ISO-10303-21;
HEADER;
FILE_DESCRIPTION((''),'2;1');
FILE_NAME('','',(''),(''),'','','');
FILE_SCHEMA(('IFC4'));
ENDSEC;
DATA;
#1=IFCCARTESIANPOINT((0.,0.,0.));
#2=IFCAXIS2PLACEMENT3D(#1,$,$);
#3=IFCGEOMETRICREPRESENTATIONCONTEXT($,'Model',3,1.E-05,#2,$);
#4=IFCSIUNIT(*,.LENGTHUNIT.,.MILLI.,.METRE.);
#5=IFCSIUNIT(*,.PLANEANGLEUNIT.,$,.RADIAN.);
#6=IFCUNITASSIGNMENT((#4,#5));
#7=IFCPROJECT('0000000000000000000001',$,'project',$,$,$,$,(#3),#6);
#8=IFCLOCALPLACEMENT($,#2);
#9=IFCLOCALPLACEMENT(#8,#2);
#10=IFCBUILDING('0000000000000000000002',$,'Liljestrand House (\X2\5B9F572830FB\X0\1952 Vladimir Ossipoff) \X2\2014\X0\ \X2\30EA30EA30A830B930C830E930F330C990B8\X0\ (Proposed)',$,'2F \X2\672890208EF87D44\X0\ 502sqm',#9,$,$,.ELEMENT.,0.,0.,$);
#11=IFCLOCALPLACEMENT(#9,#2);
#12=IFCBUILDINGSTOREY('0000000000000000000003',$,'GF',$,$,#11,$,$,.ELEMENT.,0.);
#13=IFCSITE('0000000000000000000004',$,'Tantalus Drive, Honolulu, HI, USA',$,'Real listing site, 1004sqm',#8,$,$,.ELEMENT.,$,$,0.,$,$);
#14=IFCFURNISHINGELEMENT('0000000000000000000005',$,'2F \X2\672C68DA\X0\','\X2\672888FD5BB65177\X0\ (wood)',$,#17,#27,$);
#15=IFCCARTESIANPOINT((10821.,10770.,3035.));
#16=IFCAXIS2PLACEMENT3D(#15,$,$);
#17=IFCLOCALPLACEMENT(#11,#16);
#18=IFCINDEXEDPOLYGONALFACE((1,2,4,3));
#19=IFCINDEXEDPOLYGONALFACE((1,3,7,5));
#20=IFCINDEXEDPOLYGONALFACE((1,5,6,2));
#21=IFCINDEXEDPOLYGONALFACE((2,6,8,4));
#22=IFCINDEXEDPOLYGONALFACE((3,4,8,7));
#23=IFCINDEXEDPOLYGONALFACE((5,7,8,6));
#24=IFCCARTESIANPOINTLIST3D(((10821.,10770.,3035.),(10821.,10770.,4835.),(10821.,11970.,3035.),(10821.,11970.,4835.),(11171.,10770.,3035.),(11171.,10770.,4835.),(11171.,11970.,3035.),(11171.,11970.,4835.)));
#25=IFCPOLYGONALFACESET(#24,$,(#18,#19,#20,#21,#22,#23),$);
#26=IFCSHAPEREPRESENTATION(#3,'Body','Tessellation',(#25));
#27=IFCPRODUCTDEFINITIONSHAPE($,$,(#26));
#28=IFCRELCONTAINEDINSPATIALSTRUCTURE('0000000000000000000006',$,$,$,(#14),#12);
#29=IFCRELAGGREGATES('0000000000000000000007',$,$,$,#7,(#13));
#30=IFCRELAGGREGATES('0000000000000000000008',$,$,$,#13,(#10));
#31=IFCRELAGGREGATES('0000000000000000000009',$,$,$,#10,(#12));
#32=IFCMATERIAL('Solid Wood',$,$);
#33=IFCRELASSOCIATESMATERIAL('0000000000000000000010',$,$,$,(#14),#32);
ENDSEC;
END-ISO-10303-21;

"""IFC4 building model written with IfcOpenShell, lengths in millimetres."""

from ifc_helpers import new_model, si_unit, frame, frame_2d, origin, place, context, project, spatial, rectangle, extrude, material, element, save


model = new_model("IFC4")

# Units and contexts
model_context = context("Model", 3, precision=1e-05, world=origin())
ifc_project = project(units=[si_unit("LENGTHUNIT", "METRE", prefix="MILLI"), si_unit("PLANEANGLEUNIT", "RADIAN")], contexts=[model_context])

# Site, building, storey
site_placement = place(None, origin())
site = spatial("IfcSite", under=ifc_project, at=site_placement, Name="Tantalus Drive, Honolulu, HI, USA", ObjectType="Real listing site, 1004sqm", CompositionType="ELEMENT", RefElevation=0.0)
building_placement = place(site_placement, origin())
building = spatial("IfcBuilding", under=site, at=building_placement, Name="Liljestrand House (実在・1952 Vladimir Ossipoff) — リリエストランド邸 (Proposed)", ObjectType="2F 木造軸組 502sqm", CompositionType="ELEMENT", ElevationOfRefHeight=0.0, ElevationOfTerrain=0.0)
storey_placement = place(building_placement, origin())
storey = spatial("IfcBuildingStorey", under=building, at=storey_placement, Name="GF", CompositionType="ELEMENT", Elevation=0.0)

# Shared definitions
ifc_material_1 = material(Name="Solid Wood")

# Furnishing element
furnishing_1_placement = place(storey_placement, frame((10821.0, 10770.0, 3035.0)))
element("IfcFurnishingElement", 1, at=furnishing_1_placement, inside=storey, material=ifc_material_1, Name="2F 本棚", Description="木製家具 (wood)", context=model_context, shape_type="SweptSolid", body=[
    extrude(rectangle(XDim=350.0, YDim=1200.0, at=frame_2d((175.0, 600.0))), frame((10821.0, 10770.0, 3035.0)), (0.0, 0.0, 1.0), 1800.0),
])

save(model, "model.ifc")
